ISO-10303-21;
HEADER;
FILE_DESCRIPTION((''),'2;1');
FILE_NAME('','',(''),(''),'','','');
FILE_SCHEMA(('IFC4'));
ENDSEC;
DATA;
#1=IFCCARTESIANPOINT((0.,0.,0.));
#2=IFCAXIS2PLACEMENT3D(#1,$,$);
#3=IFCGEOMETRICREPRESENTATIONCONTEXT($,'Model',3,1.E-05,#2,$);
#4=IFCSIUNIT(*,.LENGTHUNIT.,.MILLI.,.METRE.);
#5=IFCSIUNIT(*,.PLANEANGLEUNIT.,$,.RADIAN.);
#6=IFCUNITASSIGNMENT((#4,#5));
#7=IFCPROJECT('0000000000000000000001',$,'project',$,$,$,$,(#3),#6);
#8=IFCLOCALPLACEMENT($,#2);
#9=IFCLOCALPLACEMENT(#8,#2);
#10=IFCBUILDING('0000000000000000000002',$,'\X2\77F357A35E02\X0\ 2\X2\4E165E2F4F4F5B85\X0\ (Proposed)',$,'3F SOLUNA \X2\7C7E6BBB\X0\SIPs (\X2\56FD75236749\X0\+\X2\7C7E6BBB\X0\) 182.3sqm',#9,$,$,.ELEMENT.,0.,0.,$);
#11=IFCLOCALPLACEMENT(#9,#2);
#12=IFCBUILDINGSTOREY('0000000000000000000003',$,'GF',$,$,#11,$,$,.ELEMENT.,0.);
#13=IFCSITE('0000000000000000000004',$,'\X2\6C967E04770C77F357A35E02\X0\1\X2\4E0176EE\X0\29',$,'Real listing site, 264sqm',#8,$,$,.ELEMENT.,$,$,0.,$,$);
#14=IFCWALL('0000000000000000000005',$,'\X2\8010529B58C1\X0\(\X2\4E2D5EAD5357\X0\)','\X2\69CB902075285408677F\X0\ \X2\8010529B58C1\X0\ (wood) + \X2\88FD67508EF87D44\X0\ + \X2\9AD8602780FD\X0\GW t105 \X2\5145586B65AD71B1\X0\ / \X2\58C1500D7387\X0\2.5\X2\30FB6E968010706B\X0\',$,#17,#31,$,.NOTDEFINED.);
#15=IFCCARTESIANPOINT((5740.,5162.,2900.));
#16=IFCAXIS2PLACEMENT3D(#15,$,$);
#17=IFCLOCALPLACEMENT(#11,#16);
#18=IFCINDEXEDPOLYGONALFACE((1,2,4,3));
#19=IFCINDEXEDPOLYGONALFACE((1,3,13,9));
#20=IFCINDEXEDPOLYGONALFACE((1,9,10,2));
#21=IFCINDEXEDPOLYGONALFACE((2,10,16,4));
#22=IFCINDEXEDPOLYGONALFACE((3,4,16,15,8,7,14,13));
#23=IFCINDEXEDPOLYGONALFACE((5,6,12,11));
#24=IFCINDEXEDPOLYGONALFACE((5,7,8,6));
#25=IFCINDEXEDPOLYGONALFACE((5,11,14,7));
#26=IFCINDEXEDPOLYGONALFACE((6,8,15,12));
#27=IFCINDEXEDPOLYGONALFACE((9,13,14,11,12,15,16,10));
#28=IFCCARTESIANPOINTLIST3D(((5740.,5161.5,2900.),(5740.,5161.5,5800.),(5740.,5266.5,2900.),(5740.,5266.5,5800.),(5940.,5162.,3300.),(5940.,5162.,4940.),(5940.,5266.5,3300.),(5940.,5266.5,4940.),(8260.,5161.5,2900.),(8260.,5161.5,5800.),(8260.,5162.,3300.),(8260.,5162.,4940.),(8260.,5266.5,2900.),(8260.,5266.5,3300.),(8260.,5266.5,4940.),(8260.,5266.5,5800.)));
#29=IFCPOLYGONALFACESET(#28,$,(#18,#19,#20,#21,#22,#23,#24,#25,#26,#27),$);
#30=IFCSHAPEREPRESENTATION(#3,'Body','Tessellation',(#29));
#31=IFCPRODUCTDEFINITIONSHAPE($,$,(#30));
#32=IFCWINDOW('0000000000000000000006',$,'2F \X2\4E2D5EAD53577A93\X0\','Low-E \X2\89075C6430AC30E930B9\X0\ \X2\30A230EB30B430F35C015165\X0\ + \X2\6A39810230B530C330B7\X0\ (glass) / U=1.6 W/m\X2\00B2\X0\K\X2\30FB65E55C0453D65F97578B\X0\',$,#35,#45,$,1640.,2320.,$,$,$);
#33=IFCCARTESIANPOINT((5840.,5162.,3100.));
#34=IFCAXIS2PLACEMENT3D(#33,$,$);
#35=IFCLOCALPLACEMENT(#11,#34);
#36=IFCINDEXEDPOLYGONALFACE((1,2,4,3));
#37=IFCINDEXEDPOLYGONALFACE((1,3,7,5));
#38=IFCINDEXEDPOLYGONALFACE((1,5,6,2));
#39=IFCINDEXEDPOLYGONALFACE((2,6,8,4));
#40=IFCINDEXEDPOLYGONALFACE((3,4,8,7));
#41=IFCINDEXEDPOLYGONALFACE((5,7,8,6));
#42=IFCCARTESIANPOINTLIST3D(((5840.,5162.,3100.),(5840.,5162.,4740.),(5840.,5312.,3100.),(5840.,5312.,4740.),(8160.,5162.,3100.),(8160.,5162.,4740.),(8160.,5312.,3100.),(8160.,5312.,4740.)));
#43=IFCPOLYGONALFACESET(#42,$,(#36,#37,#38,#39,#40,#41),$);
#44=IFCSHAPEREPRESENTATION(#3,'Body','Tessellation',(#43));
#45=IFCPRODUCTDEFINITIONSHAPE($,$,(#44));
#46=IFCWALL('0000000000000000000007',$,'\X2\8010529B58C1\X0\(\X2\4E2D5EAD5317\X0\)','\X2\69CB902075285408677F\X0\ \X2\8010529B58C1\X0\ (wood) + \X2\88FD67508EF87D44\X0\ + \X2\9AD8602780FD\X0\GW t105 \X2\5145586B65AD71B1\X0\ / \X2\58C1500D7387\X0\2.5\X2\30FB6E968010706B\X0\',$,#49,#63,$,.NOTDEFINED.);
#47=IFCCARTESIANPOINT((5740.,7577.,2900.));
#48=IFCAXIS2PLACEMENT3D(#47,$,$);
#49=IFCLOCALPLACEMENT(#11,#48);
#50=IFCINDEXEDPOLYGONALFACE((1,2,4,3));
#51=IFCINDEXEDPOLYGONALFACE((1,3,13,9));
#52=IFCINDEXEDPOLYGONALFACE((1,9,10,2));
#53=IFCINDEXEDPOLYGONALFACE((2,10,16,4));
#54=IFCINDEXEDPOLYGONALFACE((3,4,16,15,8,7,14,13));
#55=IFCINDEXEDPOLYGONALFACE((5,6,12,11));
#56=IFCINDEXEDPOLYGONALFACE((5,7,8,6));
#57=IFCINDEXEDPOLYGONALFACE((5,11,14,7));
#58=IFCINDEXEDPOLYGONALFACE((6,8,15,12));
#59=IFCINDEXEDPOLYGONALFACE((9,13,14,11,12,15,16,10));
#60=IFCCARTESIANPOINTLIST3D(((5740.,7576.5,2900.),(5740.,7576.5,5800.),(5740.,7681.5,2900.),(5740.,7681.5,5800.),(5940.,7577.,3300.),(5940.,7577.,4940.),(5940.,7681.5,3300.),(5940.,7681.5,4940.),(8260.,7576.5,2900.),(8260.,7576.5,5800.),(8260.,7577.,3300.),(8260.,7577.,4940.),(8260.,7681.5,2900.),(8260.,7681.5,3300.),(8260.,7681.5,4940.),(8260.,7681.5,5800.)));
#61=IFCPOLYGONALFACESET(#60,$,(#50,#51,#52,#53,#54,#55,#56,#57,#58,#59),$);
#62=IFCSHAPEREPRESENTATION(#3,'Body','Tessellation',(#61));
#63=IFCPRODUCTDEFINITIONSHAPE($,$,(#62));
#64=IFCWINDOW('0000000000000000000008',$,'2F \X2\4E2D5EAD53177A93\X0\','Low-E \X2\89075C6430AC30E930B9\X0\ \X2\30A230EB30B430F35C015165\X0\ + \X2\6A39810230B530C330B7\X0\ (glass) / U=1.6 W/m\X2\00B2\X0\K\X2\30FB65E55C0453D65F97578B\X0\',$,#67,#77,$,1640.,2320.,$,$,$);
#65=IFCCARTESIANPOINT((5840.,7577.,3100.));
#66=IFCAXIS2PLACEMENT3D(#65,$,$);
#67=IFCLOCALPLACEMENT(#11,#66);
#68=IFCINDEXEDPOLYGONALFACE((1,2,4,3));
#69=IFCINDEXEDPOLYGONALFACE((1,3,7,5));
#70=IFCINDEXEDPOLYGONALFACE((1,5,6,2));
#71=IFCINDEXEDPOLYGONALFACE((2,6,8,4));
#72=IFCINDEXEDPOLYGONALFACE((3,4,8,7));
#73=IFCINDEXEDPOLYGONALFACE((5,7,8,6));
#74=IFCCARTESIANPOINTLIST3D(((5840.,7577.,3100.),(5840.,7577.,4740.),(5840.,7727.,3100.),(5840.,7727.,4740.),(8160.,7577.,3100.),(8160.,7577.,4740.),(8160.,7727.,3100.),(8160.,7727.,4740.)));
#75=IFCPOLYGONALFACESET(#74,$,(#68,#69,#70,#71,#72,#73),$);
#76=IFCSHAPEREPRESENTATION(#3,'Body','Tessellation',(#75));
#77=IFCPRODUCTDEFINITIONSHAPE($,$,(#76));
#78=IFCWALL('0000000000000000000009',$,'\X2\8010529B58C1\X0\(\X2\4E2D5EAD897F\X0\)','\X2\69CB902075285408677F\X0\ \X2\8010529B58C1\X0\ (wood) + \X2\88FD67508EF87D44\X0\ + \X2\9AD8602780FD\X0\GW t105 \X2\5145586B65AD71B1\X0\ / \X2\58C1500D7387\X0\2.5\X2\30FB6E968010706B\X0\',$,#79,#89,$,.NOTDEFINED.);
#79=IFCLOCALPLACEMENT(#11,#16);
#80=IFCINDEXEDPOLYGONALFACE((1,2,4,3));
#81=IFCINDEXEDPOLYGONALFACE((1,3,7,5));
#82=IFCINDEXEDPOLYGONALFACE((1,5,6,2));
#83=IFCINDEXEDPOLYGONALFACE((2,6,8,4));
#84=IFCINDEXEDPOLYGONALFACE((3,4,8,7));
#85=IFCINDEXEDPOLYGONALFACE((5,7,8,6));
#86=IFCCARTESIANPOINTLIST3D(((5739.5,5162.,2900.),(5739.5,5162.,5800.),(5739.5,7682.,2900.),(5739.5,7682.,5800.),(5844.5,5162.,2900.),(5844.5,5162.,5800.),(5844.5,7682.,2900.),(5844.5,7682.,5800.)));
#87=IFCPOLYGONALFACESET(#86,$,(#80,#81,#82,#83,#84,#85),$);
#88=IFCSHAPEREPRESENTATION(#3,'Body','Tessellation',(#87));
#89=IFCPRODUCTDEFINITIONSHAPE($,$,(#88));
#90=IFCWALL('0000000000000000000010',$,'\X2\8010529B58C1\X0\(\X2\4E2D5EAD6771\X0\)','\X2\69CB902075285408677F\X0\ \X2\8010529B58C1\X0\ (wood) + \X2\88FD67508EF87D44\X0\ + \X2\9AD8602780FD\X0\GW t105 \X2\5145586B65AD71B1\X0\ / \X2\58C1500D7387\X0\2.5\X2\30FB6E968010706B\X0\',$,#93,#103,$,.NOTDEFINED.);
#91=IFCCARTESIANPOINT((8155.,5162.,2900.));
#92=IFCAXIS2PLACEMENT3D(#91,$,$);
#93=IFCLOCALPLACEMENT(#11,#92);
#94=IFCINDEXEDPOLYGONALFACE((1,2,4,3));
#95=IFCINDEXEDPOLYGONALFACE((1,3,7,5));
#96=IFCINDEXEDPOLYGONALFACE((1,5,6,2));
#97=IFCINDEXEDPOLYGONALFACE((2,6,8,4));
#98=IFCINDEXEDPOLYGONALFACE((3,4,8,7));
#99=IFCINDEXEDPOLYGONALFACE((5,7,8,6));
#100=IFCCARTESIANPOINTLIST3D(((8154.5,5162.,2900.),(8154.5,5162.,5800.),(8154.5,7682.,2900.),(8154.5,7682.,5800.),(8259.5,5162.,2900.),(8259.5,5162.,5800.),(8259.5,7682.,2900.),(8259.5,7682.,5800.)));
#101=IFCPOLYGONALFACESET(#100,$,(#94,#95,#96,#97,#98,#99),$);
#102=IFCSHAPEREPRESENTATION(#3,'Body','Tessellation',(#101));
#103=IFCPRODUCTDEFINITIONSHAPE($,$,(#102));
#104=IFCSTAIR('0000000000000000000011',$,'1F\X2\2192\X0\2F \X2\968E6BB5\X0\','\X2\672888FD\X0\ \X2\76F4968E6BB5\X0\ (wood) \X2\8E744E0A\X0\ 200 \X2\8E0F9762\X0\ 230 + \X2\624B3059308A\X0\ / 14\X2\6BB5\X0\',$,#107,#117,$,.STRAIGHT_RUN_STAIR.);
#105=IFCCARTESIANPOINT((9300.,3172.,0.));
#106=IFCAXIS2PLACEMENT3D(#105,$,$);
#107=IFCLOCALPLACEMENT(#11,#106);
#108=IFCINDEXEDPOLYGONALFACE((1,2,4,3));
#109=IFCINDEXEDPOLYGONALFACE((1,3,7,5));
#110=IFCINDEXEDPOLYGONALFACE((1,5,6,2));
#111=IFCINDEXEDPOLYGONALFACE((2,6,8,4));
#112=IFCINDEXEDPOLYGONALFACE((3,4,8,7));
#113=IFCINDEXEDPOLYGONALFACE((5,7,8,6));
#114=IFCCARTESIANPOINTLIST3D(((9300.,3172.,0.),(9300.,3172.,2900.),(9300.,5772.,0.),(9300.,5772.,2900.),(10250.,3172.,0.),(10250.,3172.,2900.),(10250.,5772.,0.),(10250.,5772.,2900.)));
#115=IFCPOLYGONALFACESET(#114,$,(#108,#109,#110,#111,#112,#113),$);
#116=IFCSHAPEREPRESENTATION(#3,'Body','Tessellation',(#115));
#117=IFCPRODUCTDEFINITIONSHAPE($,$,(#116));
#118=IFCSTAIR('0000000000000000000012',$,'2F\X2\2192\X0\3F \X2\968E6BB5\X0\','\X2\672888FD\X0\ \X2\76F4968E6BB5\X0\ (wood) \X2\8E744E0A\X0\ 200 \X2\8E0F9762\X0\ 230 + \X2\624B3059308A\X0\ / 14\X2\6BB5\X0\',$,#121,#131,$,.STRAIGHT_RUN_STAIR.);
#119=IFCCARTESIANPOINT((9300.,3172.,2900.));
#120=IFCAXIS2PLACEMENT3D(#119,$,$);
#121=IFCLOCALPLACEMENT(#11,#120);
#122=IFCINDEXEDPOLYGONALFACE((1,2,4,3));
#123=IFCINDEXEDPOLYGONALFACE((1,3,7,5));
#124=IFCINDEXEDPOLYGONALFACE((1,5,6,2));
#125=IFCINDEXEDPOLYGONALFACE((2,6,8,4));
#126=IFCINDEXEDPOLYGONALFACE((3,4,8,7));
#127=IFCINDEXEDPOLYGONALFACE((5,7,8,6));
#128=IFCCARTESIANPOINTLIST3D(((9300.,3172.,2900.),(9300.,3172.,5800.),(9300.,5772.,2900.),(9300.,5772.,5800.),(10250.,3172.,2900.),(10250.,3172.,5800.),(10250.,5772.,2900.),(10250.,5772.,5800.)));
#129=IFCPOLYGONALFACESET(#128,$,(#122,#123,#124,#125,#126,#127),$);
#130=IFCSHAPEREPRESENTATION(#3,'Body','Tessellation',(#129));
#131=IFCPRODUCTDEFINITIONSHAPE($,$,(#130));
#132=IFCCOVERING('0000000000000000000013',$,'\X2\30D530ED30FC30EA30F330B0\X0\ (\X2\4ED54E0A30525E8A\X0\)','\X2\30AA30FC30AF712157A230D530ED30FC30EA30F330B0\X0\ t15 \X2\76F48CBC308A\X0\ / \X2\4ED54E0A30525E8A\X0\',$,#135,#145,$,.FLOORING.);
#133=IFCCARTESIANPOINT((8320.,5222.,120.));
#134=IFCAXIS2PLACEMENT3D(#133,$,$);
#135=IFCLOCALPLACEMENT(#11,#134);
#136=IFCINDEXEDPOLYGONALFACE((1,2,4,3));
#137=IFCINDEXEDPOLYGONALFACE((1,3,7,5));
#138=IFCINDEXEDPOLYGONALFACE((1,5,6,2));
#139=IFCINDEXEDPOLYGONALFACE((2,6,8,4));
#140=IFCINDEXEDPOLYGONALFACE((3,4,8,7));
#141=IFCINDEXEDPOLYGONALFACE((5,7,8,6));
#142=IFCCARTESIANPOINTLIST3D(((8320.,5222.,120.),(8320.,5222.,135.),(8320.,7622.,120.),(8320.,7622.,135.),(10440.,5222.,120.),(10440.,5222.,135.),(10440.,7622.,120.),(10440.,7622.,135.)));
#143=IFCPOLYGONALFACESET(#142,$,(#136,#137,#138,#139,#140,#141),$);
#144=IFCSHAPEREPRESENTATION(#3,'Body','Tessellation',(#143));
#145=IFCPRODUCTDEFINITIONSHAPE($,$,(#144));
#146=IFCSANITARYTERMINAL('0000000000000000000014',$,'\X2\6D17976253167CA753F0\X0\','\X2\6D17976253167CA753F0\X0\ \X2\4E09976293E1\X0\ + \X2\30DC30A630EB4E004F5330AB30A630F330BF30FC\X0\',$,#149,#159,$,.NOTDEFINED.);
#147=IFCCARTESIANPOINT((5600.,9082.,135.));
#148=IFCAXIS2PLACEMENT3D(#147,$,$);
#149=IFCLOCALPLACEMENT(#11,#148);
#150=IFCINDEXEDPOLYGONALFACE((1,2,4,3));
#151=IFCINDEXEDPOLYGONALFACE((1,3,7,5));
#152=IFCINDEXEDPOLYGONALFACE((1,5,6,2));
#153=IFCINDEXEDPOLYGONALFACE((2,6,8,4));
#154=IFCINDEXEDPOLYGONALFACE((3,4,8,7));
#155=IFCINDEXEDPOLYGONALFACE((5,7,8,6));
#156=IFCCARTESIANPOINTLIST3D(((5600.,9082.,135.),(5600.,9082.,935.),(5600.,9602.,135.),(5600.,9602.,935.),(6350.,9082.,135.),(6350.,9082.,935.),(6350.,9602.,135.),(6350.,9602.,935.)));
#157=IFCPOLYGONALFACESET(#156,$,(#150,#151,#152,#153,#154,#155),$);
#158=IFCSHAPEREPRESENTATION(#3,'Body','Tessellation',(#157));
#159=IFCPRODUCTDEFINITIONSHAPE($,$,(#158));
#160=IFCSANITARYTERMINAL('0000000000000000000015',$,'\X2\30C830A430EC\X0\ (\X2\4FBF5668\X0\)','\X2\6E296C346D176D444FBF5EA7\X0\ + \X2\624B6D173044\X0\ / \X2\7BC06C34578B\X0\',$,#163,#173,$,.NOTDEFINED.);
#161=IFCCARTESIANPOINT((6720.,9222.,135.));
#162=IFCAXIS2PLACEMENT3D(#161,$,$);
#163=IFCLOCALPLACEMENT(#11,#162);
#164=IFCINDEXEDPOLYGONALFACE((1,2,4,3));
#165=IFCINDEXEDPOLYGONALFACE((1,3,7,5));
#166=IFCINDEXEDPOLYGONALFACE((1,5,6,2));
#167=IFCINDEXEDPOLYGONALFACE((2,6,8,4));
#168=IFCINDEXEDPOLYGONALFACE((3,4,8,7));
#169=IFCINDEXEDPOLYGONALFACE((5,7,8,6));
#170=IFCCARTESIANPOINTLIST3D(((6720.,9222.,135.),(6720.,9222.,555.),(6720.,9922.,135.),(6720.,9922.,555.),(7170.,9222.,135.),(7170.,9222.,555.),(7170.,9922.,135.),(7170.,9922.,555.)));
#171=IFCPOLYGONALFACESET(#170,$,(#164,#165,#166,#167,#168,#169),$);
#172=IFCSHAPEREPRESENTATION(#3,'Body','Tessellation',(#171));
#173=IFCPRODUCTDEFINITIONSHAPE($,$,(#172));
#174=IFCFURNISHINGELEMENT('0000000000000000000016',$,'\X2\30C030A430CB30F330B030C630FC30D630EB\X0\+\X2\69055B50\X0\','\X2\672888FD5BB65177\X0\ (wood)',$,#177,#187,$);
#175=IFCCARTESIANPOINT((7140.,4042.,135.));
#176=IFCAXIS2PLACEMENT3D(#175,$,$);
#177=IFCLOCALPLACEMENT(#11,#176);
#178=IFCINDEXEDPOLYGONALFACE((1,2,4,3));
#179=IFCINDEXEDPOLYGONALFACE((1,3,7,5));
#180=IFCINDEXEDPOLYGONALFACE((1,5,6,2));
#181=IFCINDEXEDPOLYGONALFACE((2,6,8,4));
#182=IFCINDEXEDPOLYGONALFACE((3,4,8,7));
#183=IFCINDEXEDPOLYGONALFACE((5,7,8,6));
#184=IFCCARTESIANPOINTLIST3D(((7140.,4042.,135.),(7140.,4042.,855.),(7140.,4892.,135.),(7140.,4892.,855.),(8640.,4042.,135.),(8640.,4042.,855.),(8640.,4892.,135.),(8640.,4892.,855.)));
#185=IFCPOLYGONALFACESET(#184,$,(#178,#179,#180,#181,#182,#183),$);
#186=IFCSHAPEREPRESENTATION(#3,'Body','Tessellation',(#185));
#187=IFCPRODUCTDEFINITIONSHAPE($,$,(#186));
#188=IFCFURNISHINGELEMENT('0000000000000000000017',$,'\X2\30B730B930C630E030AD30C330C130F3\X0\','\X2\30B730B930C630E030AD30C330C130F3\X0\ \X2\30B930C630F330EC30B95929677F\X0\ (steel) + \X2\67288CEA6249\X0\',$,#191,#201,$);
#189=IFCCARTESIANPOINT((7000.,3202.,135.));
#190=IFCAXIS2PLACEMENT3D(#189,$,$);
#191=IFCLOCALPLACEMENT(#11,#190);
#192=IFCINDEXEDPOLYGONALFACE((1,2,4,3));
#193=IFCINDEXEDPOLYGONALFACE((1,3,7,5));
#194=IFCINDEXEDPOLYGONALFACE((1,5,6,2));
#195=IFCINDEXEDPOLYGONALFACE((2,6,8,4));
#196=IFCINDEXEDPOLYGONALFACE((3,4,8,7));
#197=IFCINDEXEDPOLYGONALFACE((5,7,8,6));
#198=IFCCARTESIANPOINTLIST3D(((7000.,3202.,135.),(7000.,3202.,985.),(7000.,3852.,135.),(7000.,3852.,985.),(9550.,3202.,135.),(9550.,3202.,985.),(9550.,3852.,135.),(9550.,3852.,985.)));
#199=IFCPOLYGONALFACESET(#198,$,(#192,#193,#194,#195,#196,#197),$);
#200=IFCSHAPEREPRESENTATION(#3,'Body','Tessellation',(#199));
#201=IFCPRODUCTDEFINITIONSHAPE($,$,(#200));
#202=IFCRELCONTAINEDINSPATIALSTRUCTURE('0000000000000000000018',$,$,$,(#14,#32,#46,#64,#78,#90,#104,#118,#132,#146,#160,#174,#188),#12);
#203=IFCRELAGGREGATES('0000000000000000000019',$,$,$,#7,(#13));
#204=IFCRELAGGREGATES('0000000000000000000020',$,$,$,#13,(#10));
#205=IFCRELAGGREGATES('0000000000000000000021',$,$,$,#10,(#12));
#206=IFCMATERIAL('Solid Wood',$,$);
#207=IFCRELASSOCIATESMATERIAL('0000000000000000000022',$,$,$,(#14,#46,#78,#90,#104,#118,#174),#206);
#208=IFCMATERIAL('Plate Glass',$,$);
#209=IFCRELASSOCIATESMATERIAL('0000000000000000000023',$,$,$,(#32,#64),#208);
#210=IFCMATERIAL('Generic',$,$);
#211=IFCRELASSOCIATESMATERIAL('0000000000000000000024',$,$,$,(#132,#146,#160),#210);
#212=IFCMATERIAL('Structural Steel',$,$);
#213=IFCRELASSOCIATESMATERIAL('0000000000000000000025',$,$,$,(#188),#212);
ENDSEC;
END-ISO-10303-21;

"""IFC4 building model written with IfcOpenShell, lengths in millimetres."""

from ifc_helpers import new_model, si_unit, frame, frame_2d, origin, place, context, project, spatial, rectangle, extrude, material, element, fill, save


model = new_model("IFC4")

# Units and contexts
model_context = context("Model", 3, precision=1e-05, world=origin())
ifc_project = project(units=[si_unit("LENGTHUNIT", "METRE", prefix="MILLI"), si_unit("PLANEANGLEUNIT", "RADIAN")], contexts=[model_context])

# Site, building, storey
site_placement = place(None, origin())
site = spatial("IfcSite", under=ifc_project, at=site_placement, Name="沖縄県石垣市1丁目29", ObjectType="Real listing site, 264sqm", CompositionType="ELEMENT", RefElevation=0.0)
building_placement = place(site_placement, origin())
building = spatial("IfcBuilding", under=site, at=building_placement, Name="石垣市 2世帯住宅 (Proposed)", ObjectType="3F SOLUNA 籾殻SIPs (国産杉+籾殻) 182.3sqm", CompositionType="ELEMENT", ElevationOfRefHeight=0.0, ElevationOfTerrain=0.0)
storey_placement = place(building_placement, origin())
storey = spatial("IfcBuildingStorey", under=building, at=storey_placement, Name="GF", CompositionType="ELEMENT", Elevation=0.0)

# Shared definitions
ifc_material_1 = material(Name="Solid Wood")

# Shared definitions
ifc_material_2 = material(Name="Plate Glass")

# Walls, openings, windows
wall_1_placement = place(storey_placement, frame((5740.0, 5162.0, 2900.0)))
wall_1 = element("IfcWall", 1, at=wall_1_placement, inside=storey, material=ifc_material_1, Name="耐力壁(中庭南)", Description="構造用合板 耐力壁 (wood) + 製材軸組 + 高性能GW t105 充填断熱 / 壁倍率2.5・準耐火", PredefinedType="NOTDEFINED", context=model_context, shape_type="SweptSolid", body=[
    extrude(rectangle(XDim=2520.0, YDim=105.0, at=frame_2d((1260.0, 52.0))), frame((5740.0, 5162.0, 2900.0)), (0.0, 0.0, 1.0), 2900.0),
])
opening_1_placement = place(storey_placement, frame((5840.0, 5162.0, 3100.0)))
opening_1 = element("IfcOpeningElement", 2, at=opening_1_placement, cuts=wall_1, PredefinedType="NOTDEFINED", context=model_context, shape_type="SweptSolid", body=[
    extrude(rectangle(XDim=2320.0, YDim=150.0, at=frame_2d((1160.0, 75.0))), frame((5840.0, 5162.0, 3100.0)), (0.0, 0.0, 1.0), 1640.0),
])
window_1_placement = place(storey_placement, frame((5840.0, 5162.0, 3100.0)))
window_1 = element("IfcWindow", 3, at=window_1_placement, inside=storey, material=ifc_material_2, Name="2F 中庭南窓", Description="Low-E 複層ガラス アルゴン封入 + 樹脂サッシ (glass) / U=1.6 W/m²K・日射取得型", OverallHeight=1640.0, OverallWidth=2320.0, context=model_context, shape_type="SweptSolid", body=[
    extrude(rectangle(XDim=2320.0, YDim=150.0, at=frame_2d((1160.0, 75.0))), frame((5840.0, 5162.0, 3100.0)), (0.0, 0.0, 1.0), 1640.0),
])
fill(opening_1, window_1)
wall_2_placement = place(storey_placement, frame((5740.0, 7577.0, 2900.0)))
wall_2 = element("IfcWall", 4, at=wall_2_placement, inside=storey, material=ifc_material_1, Name="耐力壁(中庭北)", Description="構造用合板 耐力壁 (wood) + 製材軸組 + 高性能GW t105 充填断熱 / 壁倍率2.5・準耐火", PredefinedType="NOTDEFINED", context=model_context, shape_type="SweptSolid", body=[
    extrude(rectangle(XDim=2520.0, YDim=105.0, at=frame_2d((1260.0, 52.0))), frame((5740.0, 7577.0, 2900.0)), (0.0, 0.0, 1.0), 2900.0),
])
opening_2_placement = place(storey_placement, frame((5840.0, 7577.0, 3100.0)))
opening_2 = element("IfcOpeningElement", 5, at=opening_2_placement, cuts=wall_2, PredefinedType="NOTDEFINED", context=model_context, shape_type="SweptSolid", body=[
    extrude(rectangle(XDim=2320.0, YDim=150.0, at=frame_2d((1160.0, 75.0))), frame((5840.0, 7577.0, 3100.0)), (0.0, 0.0, 1.0), 1640.0),
])
window_2_placement = place(storey_placement, frame((5840.0, 7577.0, 3100.0)))
window_2 = element("IfcWindow", 6, at=window_2_placement, inside=storey, material=ifc_material_2, Name="2F 中庭北窓", Description="Low-E 複層ガラス アルゴン封入 + 樹脂サッシ (glass) / U=1.6 W/m²K・日射取得型", OverallHeight=1640.0, OverallWidth=2320.0, context=model_context, shape_type="SweptSolid", body=[
    extrude(rectangle(XDim=2320.0, YDim=150.0, at=frame_2d((1160.0, 75.0))), frame((5840.0, 7577.0, 3100.0)), (0.0, 0.0, 1.0), 1640.0),
])
fill(opening_2, window_2)

# Walls
wall_3_placement = place(storey_placement, frame((5740.0, 5162.0, 2900.0)))
element("IfcWall", 7, at=wall_3_placement, inside=storey, material=ifc_material_1, Name="耐力壁(中庭西)", Description="構造用合板 耐力壁 (wood) + 製材軸組 + 高性能GW t105 充填断熱 / 壁倍率2.5・準耐火", PredefinedType="NOTDEFINED", context=model_context, shape_type="SweptSolid", body=[
    extrude(rectangle(XDim=105.0, YDim=2520.0, at=frame_2d((52.0, 1260.0))), frame((5740.0, 5162.0, 2900.0)), (0.0, 0.0, 1.0), 2900.0),
])
wall_4_placement = place(storey_placement, frame((8155.0, 5162.0, 2900.0)))
element("IfcWall", 8, at=wall_4_placement, inside=storey, material=ifc_material_1, Name="耐力壁(中庭東)", Description="構造用合板 耐力壁 (wood) + 製材軸組 + 高性能GW t105 充填断熱 / 壁倍率2.5・準耐火", PredefinedType="NOTDEFINED", context=model_context, shape_type="SweptSolid", body=[
    extrude(rectangle(XDim=105.0, YDim=2520.0, at=frame_2d((52.0, 1260.0))), frame((8155.0, 5162.0, 2900.0)), (0.0, 0.0, 1.0), 2900.0),
])

# Stairs
stair_1_placement = place(storey_placement, frame((9300.0, 3172.0, 0.0)))
element("IfcStair", 9, at=stair_1_placement, inside=storey, material=ifc_material_1, Name="1F→2F 階段", Description="木製 直階段 (wood) 蹴上 200 踏面 230 + 手すり / 14段", PredefinedType="STRAIGHT_RUN_STAIR", context=model_context, shape_type="SweptSolid", body=[
    extrude(rectangle(XDim=950.0, YDim=2600.0, at=frame_2d((475.0, 1300.0))), frame((9300.0, 3172.0, 0.0)), (0.0, 0.0, 1.0), 2900.0),
])
stair_2_placement = place(storey_placement, frame((9300.0, 3172.0, 2900.0)))
element("IfcStair", 10, at=stair_2_placement, inside=storey, material=ifc_material_1, Name="2F→3F 階段", Description="木製 直階段 (wood) 蹴上 200 踏面 230 + 手すり / 14段", PredefinedType="STRAIGHT_RUN_STAIR", context=model_context, shape_type="SweptSolid", body=[
    extrude(rectangle(XDim=950.0, YDim=2600.0, at=frame_2d((475.0, 1300.0))), frame((9300.0, 3172.0, 2900.0)), (0.0, 0.0, 1.0), 2900.0),
])

# Covering
ifc_material_3 = material(Name="Generic")
covering_placement = place(storey_placement, frame((8320.0, 5222.0, 120.0)))
element("IfcCovering", 11, at=covering_placement, inside=storey, material=ifc_material_3, Name="フローリング (仕上げ床)", Description="オーク無垢フローリング t15 直貼り / 仕上げ床", PredefinedType="FLOORING", context=model_context, shape_type="SweptSolid", body=[
    extrude(rectangle(XDim=2120.0, YDim=2400.0, at=frame_2d((1060.0, 1200.0))), frame((8320.0, 5222.0, 120.0)), (0.0, 0.0, 1.0), 15.0),
])

# Sanitary terminals
sanitary_terminal_1_placement = place(storey_placement, frame((5600.0, 9082.0, 135.0)))
element("IfcSanitaryTerminal", 12, at=sanitary_terminal_1_placement, inside=storey, material=ifc_material_3, Name="洗面化粧台", Description="洗面化粧台 三面鏡 + ボウル一体カウンター", PredefinedType="NOTDEFINED", context=model_context, shape_type="SweptSolid", body=[
    extrude(rectangle(XDim=750.0, YDim=520.0, at=frame_2d((375.0, 260.0))), frame((5600.0, 9082.0, 135.0)), (0.0, 0.0, 1.0), 800.0),
])
sanitary_terminal_2_placement = place(storey_placement, frame((6720.0, 9222.0, 135.0)))
element("IfcSanitaryTerminal", 13, at=sanitary_terminal_2_placement, inside=storey, material=ifc_material_3, Name="トイレ (便器)", Description="温水洗浄便座 + 手洗い / 節水型", PredefinedType="NOTDEFINED", context=model_context, shape_type="SweptSolid", body=[
    extrude(rectangle(XDim=450.0, YDim=700.0, at=frame_2d((225.0, 350.0))), frame((6720.0, 9222.0, 135.0)), (0.0, 0.0, 1.0), 420.0),
])

# Furnishing elements
furnishing_1_placement = place(storey_placement, frame((7140.0, 4042.0, 135.0)))
element("IfcFurnishingElement", 14, at=furnishing_1_placement, inside=storey, material=ifc_material_1, Name="ダイニングテーブル+椅子", Description="木製家具 (wood)", context=model_context, shape_type="SweptSolid", body=[
    extrude(rectangle(XDim=1500.0, YDim=850.0, at=frame_2d((750.0, 425.0))), frame((7140.0, 4042.0, 135.0)), (0.0, 0.0, 1.0), 720.0),
])
ifc_material_4 = material(Name="Structural Steel")
furnishing_2_placement = place(storey_placement, frame((7000.0, 3202.0, 135.0)))
element("IfcFurnishingElement", 15, at=furnishing_2_placement, inside=storey, material=ifc_material_4, Name="システムキッチン", Description="システムキッチン ステンレス天板 (steel) + 木質扉", context=model_context, shape_type="SweptSolid", body=[
    extrude(rectangle(XDim=2550.0, YDim=650.0, at=frame_2d((1275.0, 325.0))), frame((7000.0, 3202.0, 135.0)), (0.0, 0.0, 1.0), 850.0),
])

save(model, "model.ifc")
